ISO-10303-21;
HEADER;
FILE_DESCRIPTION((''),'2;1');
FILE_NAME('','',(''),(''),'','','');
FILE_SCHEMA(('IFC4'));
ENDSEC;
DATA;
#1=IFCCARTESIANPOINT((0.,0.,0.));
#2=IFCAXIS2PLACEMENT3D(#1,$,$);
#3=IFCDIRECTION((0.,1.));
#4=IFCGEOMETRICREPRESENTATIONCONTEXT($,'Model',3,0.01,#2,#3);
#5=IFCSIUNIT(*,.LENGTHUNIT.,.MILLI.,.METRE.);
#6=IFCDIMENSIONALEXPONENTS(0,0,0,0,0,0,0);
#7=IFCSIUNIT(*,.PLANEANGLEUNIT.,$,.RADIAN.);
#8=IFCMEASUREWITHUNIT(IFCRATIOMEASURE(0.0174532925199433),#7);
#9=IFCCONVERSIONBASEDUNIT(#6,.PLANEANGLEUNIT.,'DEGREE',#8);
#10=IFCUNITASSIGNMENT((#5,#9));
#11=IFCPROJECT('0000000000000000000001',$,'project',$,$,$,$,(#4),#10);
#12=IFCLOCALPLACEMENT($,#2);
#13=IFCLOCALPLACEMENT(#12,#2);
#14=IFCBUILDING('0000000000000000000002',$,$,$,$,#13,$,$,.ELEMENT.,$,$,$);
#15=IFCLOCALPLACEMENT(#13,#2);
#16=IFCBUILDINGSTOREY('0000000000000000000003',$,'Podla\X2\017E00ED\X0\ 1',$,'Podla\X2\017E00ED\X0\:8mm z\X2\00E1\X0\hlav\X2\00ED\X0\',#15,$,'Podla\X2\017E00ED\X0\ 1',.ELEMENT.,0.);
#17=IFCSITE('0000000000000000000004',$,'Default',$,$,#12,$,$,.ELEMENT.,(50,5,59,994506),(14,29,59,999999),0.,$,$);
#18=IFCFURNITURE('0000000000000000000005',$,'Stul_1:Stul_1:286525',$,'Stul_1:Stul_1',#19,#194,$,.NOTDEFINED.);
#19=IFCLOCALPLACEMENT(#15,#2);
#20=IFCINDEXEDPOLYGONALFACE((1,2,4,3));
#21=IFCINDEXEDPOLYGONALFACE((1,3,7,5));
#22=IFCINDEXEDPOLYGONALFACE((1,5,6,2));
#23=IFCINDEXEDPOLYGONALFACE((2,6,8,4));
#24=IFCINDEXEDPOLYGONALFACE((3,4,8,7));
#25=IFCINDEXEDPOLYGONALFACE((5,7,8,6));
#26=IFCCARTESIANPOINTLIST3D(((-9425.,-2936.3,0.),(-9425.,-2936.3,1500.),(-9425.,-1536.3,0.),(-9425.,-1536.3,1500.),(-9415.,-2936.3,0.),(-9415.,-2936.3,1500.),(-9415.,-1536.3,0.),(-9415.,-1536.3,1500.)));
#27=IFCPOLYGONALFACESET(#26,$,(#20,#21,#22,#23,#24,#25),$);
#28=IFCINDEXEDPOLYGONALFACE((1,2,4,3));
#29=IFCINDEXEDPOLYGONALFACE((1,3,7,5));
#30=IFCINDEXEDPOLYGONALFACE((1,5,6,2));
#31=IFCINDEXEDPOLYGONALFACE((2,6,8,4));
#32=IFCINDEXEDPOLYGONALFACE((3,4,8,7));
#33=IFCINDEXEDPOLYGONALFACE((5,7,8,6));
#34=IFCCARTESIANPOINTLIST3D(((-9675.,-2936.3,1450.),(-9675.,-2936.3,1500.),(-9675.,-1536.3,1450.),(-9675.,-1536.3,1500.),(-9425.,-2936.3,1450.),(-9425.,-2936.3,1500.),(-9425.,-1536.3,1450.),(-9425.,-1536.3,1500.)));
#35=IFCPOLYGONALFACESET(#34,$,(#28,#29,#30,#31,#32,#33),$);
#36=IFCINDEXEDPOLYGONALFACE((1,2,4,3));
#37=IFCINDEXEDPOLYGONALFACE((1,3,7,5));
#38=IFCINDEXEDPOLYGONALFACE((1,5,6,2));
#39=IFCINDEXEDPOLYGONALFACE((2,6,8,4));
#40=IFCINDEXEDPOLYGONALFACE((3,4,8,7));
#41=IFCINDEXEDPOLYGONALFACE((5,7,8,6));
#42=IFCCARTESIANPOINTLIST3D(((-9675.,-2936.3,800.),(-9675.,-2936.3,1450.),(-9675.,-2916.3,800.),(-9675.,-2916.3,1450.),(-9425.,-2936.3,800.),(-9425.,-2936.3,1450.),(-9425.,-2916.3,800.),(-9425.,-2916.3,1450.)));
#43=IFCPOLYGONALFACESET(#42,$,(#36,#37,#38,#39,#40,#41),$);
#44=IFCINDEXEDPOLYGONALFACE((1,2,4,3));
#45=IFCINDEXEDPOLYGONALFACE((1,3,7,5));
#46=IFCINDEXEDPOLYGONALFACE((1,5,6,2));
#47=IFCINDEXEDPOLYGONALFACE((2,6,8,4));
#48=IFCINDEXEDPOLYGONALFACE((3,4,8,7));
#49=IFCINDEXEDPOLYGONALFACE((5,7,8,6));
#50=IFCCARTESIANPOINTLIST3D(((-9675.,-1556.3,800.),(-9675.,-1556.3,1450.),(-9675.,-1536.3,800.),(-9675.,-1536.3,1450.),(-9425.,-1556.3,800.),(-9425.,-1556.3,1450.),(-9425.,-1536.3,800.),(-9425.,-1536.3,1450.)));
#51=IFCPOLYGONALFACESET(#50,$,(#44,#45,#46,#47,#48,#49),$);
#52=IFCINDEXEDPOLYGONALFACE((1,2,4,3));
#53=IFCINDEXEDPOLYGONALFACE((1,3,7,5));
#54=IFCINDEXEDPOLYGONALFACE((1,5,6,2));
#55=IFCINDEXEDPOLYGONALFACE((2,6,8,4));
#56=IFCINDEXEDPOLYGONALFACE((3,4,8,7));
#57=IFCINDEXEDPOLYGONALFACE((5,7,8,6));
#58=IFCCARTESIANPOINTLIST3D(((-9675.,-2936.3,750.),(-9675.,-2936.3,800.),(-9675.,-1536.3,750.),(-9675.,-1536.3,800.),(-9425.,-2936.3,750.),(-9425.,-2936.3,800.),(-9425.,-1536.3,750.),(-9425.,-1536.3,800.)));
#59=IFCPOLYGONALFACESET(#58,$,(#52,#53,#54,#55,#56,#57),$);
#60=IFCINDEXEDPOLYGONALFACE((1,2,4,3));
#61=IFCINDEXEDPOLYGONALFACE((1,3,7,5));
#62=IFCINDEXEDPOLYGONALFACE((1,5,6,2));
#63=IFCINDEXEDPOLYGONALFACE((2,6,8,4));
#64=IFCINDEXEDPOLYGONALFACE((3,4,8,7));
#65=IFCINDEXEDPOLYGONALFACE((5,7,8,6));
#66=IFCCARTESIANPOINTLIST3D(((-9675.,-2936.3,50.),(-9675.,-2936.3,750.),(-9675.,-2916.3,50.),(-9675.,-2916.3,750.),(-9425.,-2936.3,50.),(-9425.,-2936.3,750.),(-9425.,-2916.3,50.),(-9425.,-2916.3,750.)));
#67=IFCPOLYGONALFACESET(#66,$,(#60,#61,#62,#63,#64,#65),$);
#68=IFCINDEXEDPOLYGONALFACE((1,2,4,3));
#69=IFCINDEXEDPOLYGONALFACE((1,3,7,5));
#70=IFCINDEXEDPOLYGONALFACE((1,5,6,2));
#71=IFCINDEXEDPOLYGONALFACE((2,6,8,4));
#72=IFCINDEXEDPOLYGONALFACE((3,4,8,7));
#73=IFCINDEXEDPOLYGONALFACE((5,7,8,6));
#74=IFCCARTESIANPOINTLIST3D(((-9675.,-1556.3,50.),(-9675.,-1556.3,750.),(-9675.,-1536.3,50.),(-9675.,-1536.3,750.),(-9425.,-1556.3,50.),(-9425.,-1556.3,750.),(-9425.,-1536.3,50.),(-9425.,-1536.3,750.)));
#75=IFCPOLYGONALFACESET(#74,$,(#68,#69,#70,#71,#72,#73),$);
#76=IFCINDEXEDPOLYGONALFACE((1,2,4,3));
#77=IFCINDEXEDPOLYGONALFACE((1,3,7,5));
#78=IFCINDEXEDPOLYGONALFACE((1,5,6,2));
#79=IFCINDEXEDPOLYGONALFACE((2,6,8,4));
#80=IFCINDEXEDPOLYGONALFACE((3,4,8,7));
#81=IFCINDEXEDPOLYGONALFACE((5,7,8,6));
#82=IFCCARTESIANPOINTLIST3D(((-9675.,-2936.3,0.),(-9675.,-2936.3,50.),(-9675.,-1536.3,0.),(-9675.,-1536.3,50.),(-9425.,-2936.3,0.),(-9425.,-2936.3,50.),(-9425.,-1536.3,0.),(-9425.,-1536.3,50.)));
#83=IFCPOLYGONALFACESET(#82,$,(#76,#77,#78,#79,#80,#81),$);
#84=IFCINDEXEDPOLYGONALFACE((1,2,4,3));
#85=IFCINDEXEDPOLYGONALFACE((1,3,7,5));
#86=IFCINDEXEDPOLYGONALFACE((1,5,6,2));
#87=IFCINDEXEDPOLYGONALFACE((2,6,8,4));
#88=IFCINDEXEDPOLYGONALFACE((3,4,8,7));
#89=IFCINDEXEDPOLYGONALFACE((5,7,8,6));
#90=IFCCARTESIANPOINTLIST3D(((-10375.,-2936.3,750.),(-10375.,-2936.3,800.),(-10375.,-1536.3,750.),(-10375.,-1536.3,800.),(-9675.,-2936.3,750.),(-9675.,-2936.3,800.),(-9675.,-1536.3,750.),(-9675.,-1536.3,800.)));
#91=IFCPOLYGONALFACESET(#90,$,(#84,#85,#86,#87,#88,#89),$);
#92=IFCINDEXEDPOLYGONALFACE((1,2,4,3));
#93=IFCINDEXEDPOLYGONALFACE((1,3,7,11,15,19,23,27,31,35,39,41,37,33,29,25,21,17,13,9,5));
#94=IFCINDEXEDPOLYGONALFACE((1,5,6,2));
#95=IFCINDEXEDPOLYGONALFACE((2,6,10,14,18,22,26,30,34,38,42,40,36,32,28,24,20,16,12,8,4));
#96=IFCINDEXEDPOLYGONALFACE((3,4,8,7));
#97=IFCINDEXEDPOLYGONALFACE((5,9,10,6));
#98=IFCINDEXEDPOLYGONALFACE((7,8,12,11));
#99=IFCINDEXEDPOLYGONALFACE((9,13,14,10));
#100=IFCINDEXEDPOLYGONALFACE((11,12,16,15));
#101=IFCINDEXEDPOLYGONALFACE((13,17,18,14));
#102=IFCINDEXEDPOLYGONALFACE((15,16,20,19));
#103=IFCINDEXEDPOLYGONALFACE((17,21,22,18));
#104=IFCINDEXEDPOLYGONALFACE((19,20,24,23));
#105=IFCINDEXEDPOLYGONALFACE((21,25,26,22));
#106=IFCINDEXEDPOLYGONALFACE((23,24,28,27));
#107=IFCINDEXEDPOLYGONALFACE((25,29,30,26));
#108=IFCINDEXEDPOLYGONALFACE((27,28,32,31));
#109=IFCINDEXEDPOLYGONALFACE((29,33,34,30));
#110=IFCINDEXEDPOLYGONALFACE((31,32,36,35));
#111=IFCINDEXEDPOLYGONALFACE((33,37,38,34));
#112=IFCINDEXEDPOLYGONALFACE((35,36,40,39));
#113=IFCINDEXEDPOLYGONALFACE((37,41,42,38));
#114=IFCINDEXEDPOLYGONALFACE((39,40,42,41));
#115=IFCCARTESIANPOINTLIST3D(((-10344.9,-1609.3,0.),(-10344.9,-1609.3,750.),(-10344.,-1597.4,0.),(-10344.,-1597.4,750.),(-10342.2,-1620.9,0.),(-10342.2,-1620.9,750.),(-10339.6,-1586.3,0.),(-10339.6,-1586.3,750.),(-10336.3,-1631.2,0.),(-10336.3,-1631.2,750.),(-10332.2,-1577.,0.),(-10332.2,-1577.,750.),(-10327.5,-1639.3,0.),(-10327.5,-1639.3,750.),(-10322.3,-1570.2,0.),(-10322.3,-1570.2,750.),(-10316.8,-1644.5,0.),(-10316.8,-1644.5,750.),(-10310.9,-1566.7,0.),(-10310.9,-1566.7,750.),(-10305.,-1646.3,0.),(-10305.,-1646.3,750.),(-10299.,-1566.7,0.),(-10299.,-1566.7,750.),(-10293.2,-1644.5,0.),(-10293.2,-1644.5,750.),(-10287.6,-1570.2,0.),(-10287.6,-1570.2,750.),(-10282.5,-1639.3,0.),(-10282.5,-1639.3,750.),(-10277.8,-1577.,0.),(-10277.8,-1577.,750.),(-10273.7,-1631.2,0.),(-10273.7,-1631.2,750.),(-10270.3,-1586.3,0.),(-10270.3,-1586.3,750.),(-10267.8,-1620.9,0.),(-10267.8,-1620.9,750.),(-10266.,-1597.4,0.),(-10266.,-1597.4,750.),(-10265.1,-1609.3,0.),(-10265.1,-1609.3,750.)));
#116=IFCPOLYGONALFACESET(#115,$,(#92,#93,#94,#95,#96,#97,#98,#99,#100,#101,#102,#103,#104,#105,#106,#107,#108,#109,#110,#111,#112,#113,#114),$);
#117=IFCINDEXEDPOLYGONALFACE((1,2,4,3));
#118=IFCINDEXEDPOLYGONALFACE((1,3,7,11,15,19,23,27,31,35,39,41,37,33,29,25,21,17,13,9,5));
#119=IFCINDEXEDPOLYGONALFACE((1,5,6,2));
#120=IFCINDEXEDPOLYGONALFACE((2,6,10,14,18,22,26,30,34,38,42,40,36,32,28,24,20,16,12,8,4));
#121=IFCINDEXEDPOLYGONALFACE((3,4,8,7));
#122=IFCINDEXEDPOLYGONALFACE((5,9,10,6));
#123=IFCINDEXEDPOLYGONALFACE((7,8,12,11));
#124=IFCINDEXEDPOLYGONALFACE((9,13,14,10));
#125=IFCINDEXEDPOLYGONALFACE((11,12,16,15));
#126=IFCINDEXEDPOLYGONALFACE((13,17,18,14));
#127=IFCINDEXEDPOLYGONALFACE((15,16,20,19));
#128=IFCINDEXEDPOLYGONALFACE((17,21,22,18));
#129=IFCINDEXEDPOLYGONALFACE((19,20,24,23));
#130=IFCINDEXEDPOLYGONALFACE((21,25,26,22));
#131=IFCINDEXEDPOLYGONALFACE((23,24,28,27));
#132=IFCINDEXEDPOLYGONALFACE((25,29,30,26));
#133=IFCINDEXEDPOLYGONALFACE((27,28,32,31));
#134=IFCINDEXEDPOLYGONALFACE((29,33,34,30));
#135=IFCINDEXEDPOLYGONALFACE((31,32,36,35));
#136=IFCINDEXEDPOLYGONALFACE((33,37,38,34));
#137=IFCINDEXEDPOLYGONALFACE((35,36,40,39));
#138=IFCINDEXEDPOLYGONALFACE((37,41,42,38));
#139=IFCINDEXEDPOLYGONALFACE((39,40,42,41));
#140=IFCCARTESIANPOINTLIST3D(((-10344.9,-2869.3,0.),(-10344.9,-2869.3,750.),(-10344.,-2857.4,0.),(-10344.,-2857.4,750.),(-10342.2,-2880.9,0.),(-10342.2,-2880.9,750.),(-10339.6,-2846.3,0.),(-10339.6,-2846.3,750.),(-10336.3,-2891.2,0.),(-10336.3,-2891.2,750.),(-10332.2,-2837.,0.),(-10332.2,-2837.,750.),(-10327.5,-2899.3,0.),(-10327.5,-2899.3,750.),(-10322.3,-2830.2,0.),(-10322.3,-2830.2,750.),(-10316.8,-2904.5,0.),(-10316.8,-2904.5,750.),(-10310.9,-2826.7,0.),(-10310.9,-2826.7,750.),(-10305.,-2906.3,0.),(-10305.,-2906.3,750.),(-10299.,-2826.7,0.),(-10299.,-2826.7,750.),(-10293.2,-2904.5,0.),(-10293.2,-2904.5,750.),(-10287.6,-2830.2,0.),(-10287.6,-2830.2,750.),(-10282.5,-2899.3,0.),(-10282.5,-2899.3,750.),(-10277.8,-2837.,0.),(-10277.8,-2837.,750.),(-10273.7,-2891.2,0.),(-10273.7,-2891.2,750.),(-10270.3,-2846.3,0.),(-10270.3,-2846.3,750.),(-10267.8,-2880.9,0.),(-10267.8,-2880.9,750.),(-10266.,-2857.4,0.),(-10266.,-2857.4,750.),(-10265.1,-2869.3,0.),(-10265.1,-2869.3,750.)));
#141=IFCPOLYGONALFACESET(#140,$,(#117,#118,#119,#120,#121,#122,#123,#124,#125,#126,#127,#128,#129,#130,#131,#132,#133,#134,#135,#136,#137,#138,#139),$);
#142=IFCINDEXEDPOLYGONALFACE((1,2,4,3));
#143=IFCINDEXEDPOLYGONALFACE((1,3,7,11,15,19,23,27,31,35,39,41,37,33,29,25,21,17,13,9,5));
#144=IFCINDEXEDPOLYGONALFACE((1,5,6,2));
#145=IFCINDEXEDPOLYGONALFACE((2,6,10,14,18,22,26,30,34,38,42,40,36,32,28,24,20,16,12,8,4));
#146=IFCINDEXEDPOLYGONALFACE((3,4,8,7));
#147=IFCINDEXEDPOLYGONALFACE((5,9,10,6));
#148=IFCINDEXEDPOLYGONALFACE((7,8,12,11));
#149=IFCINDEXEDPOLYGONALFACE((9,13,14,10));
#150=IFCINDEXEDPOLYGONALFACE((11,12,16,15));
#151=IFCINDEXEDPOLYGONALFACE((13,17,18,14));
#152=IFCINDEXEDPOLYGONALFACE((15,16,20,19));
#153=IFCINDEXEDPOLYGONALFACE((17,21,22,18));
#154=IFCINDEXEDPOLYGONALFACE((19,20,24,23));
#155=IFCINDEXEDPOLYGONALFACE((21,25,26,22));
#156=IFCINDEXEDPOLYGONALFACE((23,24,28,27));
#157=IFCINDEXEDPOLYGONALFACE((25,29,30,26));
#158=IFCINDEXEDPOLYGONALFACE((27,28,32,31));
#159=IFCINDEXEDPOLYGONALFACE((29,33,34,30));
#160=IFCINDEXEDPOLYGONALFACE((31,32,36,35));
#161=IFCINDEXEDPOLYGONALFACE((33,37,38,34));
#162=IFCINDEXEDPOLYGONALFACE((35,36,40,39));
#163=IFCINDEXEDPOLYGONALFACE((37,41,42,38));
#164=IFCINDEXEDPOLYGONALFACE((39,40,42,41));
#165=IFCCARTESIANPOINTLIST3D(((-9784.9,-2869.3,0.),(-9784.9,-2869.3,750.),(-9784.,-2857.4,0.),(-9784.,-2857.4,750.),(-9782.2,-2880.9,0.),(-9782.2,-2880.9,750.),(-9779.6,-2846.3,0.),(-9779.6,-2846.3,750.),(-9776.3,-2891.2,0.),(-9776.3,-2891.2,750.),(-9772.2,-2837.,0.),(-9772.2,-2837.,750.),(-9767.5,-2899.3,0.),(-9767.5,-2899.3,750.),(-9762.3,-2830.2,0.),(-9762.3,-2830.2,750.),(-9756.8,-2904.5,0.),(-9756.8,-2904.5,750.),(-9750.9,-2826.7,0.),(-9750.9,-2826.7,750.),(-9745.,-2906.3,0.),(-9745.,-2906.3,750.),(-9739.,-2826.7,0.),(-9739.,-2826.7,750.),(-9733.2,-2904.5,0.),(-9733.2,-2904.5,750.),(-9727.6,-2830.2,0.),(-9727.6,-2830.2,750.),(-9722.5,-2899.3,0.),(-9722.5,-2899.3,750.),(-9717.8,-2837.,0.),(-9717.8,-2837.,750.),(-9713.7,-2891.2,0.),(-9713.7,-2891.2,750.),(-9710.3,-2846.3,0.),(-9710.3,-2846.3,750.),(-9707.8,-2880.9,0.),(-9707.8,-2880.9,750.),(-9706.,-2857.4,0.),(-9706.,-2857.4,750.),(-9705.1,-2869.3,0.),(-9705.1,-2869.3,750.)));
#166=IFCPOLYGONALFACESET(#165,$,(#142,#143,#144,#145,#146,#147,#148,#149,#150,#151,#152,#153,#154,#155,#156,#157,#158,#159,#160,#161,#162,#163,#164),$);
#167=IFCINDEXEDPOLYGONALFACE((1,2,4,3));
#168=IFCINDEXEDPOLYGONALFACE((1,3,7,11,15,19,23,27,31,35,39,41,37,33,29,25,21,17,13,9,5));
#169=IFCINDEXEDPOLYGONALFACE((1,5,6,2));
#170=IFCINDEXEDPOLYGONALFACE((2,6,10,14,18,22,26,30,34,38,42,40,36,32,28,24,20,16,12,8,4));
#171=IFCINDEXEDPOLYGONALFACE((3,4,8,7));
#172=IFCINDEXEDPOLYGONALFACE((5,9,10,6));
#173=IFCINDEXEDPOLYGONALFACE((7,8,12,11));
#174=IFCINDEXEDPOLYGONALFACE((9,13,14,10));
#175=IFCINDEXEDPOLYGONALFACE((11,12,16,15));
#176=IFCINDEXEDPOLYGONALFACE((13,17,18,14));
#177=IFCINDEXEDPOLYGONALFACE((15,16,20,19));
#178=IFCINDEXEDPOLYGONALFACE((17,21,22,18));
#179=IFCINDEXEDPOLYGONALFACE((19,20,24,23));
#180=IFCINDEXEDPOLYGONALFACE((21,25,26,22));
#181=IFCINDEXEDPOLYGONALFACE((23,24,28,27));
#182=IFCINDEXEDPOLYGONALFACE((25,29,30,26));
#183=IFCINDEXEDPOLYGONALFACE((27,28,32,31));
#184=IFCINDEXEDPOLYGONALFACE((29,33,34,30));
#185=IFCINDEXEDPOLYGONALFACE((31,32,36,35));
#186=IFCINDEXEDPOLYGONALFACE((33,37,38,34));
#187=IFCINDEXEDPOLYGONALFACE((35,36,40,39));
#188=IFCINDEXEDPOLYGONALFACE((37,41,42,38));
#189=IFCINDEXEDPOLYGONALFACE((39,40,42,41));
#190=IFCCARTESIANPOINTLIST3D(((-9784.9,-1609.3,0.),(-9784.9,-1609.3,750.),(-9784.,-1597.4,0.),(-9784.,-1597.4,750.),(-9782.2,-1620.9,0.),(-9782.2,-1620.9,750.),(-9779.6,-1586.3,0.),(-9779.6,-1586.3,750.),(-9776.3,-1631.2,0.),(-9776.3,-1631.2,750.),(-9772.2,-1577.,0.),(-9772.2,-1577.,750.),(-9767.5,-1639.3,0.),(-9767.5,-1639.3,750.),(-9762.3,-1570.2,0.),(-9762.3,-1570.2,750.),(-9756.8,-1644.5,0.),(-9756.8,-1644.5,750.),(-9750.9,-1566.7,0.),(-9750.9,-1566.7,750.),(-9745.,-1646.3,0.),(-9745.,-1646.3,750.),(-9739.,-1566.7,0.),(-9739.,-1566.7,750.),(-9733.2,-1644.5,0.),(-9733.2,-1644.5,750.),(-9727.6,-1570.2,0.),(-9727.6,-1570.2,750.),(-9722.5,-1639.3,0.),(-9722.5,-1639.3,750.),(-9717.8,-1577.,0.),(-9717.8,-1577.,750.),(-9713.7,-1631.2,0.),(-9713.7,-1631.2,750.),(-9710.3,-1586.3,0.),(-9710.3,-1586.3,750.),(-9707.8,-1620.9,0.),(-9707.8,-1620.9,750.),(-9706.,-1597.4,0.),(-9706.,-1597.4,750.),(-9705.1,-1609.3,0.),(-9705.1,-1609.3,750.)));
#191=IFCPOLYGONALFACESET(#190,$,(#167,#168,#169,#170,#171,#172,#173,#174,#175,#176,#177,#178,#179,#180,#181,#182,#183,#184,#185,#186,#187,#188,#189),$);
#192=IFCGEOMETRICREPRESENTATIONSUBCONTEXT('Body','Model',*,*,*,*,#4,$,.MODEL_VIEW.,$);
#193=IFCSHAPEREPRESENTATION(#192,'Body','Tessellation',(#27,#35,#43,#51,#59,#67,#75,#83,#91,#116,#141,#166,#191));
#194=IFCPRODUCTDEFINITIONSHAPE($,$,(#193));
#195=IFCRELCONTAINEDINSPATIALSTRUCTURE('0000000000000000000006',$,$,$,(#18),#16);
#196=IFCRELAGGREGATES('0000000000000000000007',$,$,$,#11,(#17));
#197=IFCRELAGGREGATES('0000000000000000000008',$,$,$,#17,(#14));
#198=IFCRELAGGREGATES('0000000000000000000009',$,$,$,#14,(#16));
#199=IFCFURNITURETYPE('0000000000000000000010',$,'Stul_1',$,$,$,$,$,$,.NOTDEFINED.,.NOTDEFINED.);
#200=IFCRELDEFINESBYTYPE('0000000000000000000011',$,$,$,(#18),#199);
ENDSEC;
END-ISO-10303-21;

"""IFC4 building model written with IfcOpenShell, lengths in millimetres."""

from ifc_helpers import new_model, entity, si_unit, converted_unit, direction, frame, frame_2d, origin, origin_2d_with_axis, place, context, subcontext, project, spatial, rectangle, circle, extrude, source, transform, mapped, type_object, type_shapes, element, save


model = new_model("IFC4")

# Units and contexts
model_context = context("Model", 3, precision=0.01, world=origin(), true_north=direction((0.0, 1.0)))
body_context = subcontext(model_context, "Body", "Model", "MODEL_VIEW")
ifc_project = project(units=[si_unit("LENGTHUNIT", "METRE", prefix="MILLI"), converted_unit("PLANEANGLEUNIT", "DEGREE", entity("IfcRatioMeasure", 0.0174532925199433), si_unit("PLANEANGLEUNIT", "RADIAN"), dimensions=[0, 0, 0, 0, 0, 0, 0])], contexts=[model_context])

# Site, building, storey
site_placement = place(None, origin())
site = spatial("IfcSite", under=ifc_project, at=site_placement, Name="Default", CompositionType="ELEMENT", RefLatitude=(50, 5, 59, 994506), RefLongitude=(14, 29, 59, 999999), RefElevation=0.0)
building_placement = place(site_placement, origin())
building = spatial("IfcBuilding", under=site, at=building_placement, CompositionType="ELEMENT")
storey_placement = place(building_placement, origin())
storey = spatial("IfcBuildingStorey", under=building, at=storey_placement, Name="Podlaží 1", ObjectType="Podlaží:8mm záhlaví", LongName="Podlaží 1", CompositionType="ELEMENT", Elevation=0.0)

# Furniture
furniture_type = type_object("IfcFurnitureType", Name="Stul_1", AssemblyPlace="NOTDEFINED", PredefinedType="NOTDEFINED")
shared_shape_1 = source(origin(), body_context, "Body", "SweptSolid", [
    extrude(rectangle(XDim=1400.0, YDim=10.0, at=origin_2d_with_axis()), frame((0.0, 605.0, 0.0), z_axis=(0.0, 0.0, 1.0), x_axis=(-1.0, 0.0, 0.0)), (0.0, 0.0, 1.0), 1500.0),
    extrude(rectangle(XDim=1400.0, YDim=250.0, at=frame_2d((0.0, 0.0), x_axis=(1.0, 0.0))), frame((0.0, 475.0, 1450.0), z_axis=(0.0, 0.0, 1.0), x_axis=(-1.0, 0.0, 0.0)), (0.0, 0.0, 1.0), 50.0),
    extrude(rectangle(XDim=20.0, YDim=250.0, at=origin_2d_with_axis()), frame((690.0, 475.0, 800.0), z_axis=(0.0, 0.0, 1.0), x_axis=(-1.0, 0.0, 0.0)), (0.0, 0.0, 1.0), 650.0),
    extrude(rectangle(XDim=20.0, YDim=250.0, at=frame_2d((0.0, 0.0), x_axis=(1.0, 0.0))), frame((-690.0, 475.0, 800.0), z_axis=(0.0, 0.0, 1.0), x_axis=(-1.0, 0.0, 0.0)), (0.0, 0.0, 1.0), 650.0),
    extrude(rectangle(XDim=1400.0, YDim=250.0, at=origin_2d_with_axis()), frame((0.0, 475.0, 750.0), z_axis=(0.0, 0.0, 1.0), x_axis=(-1.0, 0.0, 0.0)), (0.0, 0.0, 1.0), 50.0),
    extrude(rectangle(XDim=20.0, YDim=250.0, at=origin_2d_with_axis()), frame((690.0, 475.0, 50.0), z_axis=(0.0, 0.0, 1.0), x_axis=(-1.0, 0.0, 0.0)), (0.0, 0.0, 1.0), 700.0),
    extrude(rectangle(XDim=20.0, YDim=250.0, at=frame_2d((0.0, 0.0), x_axis=(1.0, 0.0))), frame((-690.0, 475.0, 50.0), z_axis=(0.0, 0.0, 1.0), x_axis=(-1.0, 0.0, 0.0)), (0.0, 0.0, 1.0), 700.0),
    extrude(rectangle(XDim=1400.0, YDim=250.0, at=origin_2d_with_axis()), frame((0.0, 475.0, 0.0), z_axis=(0.0, 0.0, 1.0), x_axis=(-1.0, 0.0, 0.0)), (0.0, 0.0, 1.0), 50.0),
    extrude(rectangle(XDim=1400.0, YDim=700.0, at=origin_2d_with_axis()), frame((0.0, 0.0, 750.0), z_axis=(0.0, 0.0, 1.0), x_axis=(-1.0, 0.0, 0.0)), (0.0, 0.0, 1.0), 50.0),
    extrude(circle(Radius=40.0, at=frame_2d((0.0, 0.0), x_axis=(1.0, 0.0))), frame((-630.0, -280.0, 0.0)), (0.0, 0.0, 1.0), 750.0),
    extrude(circle(Radius=40.0, at=frame_2d((0.0, 0.0), x_axis=(1.0, 0.0))), frame((630.0, -280.0, 0.0)), (0.0, 0.0, 1.0), 750.0),
    extrude(circle(Radius=40.0, at=frame_2d((0.0, 0.0), x_axis=(1.0, 0.0))), frame((630.0, 280.0, 0.0)), (0.0, 0.0, 1.0), 750.0),
    extrude(circle(Radius=40.0, at=frame_2d((0.0, 0.0), x_axis=(1.0, 0.0))), frame((-630.0, 280.0, 0.0)), (0.0, 0.0, 1.0), 750.0),
])
type_shapes(furniture_type, [shared_shape_1])
for number, where, z_axis, x_axis, name in (
    (1, (-10025.0, -2236.3, 0.0), (0.0, 0.0, 1.0), (0.0, -1.0, 0.0), "Stul_1:Stul_1:286525"),
):
    element("IfcFurniture", number, at=place(storey_placement, frame(where, z_axis=z_axis, x_axis=x_axis)), inside=storey, type_object=furniture_type, Name=name, ObjectType="Stul_1:Stul_1", PredefinedType="NOTDEFINED", context=body_context, shape_type="MappedRepresentation", body=[
        mapped(shared_shape_1, transform((0.0, 0.0, 0.0), scale=1.0)),
    ])

save(model, "model.ifc")
